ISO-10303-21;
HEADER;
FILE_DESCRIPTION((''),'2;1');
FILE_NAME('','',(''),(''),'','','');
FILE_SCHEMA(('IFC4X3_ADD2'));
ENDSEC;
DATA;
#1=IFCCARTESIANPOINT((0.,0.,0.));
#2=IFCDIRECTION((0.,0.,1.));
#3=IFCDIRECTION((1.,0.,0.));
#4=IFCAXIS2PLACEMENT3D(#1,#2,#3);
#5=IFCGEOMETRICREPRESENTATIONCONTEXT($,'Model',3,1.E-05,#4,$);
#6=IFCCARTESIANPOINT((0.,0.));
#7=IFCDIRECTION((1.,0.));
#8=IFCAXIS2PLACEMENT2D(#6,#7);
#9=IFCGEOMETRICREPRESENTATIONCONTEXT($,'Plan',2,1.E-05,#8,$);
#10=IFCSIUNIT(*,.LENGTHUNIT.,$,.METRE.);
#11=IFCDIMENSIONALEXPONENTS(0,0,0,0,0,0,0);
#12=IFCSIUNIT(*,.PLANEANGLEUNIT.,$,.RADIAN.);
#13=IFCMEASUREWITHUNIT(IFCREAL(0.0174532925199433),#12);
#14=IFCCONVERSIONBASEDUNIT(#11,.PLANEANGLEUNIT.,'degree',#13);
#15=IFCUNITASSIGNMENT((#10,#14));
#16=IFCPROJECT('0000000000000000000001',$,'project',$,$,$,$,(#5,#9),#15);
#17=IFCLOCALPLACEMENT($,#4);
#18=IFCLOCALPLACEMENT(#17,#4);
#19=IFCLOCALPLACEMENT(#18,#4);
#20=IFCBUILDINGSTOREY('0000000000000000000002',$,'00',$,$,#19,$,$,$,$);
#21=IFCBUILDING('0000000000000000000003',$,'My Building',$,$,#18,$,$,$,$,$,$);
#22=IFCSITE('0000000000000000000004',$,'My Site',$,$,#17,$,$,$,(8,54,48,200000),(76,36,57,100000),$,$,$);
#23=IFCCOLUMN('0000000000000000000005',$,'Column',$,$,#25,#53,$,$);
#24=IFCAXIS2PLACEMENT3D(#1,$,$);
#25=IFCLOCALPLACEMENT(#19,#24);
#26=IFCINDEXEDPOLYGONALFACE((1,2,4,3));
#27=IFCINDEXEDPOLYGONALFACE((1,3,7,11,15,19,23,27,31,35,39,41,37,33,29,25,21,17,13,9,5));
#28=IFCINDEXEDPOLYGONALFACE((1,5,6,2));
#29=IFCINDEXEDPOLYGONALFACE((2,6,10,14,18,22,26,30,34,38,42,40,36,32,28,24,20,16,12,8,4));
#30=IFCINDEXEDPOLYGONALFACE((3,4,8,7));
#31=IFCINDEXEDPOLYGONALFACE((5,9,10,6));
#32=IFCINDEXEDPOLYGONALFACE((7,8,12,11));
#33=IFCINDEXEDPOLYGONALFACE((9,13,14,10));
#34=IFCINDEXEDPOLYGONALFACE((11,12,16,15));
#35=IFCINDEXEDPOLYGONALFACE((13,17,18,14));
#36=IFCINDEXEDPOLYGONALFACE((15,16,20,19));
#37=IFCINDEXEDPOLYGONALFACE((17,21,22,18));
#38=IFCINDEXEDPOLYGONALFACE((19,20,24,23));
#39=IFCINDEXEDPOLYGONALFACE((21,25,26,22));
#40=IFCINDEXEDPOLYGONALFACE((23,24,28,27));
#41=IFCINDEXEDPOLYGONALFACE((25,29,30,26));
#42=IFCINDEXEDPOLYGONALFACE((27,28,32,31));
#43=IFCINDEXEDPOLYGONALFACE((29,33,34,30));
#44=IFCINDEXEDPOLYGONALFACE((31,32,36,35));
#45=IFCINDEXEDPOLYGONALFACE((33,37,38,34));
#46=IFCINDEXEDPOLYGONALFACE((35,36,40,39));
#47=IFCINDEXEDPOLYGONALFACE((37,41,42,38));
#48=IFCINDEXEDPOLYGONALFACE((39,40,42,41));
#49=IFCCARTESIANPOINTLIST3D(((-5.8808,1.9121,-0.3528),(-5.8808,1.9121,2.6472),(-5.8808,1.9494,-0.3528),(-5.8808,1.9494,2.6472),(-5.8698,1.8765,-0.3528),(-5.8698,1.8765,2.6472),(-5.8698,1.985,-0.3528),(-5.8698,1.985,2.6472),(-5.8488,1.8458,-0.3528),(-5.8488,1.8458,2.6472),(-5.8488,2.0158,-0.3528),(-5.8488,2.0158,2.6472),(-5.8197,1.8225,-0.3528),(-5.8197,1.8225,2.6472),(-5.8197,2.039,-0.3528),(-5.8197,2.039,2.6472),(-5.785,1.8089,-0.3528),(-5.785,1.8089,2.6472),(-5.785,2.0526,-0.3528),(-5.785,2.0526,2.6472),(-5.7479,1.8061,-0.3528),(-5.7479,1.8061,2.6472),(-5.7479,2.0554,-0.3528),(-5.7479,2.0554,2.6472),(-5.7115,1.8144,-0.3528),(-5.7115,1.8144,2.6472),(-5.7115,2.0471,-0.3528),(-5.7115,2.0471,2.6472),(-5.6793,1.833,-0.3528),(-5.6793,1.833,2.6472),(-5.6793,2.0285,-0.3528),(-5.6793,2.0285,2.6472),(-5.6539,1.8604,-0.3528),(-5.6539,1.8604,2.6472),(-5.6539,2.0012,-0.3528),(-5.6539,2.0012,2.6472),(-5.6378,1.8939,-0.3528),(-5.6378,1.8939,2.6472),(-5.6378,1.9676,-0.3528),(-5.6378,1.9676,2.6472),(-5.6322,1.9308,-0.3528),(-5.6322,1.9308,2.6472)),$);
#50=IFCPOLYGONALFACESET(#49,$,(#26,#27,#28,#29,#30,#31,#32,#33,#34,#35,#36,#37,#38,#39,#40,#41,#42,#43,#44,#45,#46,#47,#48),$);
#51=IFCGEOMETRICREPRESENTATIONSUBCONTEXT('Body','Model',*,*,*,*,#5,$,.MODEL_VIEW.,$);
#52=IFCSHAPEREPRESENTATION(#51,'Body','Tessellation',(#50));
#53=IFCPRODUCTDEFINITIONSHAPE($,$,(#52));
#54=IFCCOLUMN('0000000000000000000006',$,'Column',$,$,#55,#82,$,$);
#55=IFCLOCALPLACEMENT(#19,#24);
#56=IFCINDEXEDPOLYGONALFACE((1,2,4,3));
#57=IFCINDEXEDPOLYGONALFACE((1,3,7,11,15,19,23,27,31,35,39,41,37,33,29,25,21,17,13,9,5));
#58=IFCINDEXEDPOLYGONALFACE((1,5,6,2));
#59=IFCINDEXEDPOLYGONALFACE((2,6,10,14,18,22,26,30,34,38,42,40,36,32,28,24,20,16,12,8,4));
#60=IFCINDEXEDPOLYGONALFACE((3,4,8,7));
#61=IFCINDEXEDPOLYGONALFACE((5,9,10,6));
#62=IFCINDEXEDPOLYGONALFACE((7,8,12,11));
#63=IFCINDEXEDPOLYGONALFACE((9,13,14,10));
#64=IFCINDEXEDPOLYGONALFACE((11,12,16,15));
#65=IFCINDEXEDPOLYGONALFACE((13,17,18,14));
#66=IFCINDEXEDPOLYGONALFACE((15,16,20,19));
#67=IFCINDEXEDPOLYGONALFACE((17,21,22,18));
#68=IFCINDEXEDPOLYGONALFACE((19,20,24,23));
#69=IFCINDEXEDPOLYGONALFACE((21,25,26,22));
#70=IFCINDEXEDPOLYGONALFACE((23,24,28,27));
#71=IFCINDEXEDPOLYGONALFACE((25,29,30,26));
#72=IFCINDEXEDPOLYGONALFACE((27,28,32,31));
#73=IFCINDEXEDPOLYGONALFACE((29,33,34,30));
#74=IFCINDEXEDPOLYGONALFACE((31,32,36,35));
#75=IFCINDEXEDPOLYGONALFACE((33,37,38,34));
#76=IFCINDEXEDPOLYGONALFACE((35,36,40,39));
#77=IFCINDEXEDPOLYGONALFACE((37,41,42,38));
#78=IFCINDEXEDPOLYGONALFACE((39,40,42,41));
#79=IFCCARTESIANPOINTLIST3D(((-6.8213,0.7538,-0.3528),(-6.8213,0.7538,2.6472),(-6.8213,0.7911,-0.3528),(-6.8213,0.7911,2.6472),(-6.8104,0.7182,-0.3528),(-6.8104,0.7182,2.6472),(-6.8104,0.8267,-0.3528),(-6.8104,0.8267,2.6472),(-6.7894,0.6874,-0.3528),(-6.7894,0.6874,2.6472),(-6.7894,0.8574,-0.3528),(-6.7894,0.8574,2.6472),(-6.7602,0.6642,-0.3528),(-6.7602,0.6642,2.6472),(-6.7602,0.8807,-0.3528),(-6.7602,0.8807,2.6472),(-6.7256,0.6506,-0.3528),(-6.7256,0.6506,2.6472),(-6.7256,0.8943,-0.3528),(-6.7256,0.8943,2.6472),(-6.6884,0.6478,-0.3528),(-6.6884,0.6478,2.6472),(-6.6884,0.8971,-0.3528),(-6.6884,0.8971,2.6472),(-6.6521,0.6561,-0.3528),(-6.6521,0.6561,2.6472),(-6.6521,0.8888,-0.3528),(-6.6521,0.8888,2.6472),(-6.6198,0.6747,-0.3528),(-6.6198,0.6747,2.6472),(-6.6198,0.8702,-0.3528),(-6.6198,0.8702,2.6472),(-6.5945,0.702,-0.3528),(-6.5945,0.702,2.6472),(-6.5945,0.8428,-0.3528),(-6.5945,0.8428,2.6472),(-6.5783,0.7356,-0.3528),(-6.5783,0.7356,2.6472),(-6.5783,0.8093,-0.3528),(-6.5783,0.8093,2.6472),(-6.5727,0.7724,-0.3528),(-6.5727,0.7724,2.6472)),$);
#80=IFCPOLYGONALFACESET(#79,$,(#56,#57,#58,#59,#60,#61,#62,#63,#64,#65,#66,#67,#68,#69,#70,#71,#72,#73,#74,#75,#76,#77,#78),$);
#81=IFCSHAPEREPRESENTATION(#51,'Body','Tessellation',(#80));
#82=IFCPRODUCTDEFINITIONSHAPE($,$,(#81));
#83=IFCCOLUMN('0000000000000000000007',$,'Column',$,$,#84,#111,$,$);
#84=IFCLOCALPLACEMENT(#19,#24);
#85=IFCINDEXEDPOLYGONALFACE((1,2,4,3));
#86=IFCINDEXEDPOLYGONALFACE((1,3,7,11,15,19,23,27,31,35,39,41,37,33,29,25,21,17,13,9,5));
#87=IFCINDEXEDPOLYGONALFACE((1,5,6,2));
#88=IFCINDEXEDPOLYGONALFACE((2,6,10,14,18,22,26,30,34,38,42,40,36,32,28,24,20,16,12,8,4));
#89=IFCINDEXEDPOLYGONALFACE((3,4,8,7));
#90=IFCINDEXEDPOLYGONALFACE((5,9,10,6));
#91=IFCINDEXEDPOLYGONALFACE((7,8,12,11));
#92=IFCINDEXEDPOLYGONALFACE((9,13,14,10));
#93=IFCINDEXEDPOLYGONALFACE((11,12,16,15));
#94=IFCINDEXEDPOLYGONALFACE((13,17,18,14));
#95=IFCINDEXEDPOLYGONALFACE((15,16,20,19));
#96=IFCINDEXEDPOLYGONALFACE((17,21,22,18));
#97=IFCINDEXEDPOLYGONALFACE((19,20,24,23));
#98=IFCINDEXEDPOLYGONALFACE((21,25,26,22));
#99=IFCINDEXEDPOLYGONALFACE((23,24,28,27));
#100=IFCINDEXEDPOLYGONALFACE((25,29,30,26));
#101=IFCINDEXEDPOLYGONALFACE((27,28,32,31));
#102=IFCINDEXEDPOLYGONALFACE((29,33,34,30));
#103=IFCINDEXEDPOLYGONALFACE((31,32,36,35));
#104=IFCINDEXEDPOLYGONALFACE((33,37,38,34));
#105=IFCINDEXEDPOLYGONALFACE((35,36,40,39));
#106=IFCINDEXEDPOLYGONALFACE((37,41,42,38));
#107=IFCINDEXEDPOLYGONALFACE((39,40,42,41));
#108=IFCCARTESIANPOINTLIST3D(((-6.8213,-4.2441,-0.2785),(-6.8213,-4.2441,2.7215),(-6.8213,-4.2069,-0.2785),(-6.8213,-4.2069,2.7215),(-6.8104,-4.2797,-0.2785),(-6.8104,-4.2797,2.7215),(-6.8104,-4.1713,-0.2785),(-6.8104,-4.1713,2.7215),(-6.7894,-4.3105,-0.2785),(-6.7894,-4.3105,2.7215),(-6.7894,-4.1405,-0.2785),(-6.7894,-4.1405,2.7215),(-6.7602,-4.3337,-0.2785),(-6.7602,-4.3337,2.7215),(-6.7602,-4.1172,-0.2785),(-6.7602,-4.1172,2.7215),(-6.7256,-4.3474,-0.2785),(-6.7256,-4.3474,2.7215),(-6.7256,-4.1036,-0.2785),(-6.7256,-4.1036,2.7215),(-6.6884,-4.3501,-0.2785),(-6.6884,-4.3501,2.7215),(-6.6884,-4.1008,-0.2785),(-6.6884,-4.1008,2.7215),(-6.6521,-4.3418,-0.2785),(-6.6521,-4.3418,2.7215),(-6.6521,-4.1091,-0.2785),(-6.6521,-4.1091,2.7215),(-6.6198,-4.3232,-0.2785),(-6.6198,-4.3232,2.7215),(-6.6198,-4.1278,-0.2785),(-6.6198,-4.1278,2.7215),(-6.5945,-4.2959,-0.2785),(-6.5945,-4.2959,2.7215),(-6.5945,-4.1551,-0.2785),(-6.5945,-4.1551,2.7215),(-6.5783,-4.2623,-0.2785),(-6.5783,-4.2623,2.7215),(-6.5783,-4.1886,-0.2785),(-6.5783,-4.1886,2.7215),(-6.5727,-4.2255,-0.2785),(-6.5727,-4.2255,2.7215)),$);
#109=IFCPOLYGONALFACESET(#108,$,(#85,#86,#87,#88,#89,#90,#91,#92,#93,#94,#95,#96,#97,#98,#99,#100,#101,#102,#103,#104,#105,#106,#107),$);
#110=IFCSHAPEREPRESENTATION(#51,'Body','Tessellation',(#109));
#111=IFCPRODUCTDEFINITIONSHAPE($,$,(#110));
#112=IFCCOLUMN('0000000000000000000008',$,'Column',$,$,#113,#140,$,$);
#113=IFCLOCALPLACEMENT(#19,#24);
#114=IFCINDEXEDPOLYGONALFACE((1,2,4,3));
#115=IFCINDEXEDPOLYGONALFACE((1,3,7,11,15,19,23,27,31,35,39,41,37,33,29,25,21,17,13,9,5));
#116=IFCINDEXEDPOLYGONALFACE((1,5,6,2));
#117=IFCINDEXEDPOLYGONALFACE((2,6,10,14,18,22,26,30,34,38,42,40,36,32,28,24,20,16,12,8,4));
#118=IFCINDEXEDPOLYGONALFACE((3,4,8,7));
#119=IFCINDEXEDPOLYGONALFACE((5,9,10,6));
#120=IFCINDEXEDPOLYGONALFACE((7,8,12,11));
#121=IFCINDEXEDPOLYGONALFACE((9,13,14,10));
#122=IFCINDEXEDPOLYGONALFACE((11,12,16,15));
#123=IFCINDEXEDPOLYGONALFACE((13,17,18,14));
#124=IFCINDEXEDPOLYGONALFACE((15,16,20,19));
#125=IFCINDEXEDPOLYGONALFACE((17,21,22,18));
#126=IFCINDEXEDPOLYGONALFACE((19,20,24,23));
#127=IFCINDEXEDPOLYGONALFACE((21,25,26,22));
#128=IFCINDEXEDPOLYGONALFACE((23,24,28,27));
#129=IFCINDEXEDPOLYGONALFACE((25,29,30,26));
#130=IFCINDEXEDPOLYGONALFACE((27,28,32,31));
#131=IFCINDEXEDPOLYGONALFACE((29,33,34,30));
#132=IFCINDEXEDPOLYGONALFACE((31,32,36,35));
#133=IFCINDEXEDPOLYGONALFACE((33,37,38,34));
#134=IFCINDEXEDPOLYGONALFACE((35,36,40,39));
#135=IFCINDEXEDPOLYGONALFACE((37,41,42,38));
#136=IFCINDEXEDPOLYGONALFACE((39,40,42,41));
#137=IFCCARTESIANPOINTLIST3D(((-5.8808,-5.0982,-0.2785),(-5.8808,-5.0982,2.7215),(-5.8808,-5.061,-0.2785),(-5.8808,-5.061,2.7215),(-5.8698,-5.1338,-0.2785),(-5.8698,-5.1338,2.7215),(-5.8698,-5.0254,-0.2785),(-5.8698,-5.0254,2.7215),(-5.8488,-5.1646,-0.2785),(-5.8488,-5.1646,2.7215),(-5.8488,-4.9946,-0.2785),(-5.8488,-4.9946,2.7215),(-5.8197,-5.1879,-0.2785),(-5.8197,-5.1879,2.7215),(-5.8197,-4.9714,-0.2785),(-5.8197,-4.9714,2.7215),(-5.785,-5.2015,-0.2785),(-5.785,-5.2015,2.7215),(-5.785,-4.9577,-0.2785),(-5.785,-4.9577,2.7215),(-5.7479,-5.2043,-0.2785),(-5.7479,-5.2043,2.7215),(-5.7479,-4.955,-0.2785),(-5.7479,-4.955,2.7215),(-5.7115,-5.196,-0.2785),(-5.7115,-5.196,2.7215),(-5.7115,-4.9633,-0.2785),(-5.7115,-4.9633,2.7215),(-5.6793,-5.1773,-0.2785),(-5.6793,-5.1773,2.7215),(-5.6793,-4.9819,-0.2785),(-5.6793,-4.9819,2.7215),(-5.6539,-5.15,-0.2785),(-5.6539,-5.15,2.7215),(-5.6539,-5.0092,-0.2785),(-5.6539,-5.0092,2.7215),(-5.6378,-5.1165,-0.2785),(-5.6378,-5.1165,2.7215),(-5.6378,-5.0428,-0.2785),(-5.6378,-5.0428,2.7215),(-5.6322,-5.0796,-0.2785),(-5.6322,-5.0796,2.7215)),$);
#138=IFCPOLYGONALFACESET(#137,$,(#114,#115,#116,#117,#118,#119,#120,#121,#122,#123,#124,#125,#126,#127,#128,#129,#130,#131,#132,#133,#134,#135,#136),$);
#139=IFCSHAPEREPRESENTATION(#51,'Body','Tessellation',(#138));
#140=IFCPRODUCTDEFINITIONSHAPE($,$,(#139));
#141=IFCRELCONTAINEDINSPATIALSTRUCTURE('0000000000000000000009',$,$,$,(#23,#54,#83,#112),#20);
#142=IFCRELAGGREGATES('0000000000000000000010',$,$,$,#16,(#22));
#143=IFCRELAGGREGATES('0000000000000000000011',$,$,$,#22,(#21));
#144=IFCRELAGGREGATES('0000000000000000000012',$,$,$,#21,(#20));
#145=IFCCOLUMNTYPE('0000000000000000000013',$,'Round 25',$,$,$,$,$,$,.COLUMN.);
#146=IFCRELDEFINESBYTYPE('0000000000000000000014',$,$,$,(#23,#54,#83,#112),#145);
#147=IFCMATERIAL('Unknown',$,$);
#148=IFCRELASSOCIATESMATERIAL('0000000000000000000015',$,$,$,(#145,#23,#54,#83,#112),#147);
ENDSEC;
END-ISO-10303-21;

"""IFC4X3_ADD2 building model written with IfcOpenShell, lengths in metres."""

from ifc_helpers import new_model, entity, si_unit, converted_unit, frame, origin_with_axes, origin_2d_with_axis, place, context, subcontext, project, spatial, circle, extrude, material, material_profile, profile_set, profile_usage, type_object, element, save


model = new_model("IFC4X3_ADD2")

# Units and contexts
model_context = context("Model", 3, precision=1e-05, world=origin_with_axes())
plan_context = context("Plan", 2, precision=1e-05, world=origin_2d_with_axis())
body_context = subcontext(model_context, "Body", "Model", "MODEL_VIEW")
ifc_project = project(units=[si_unit("LENGTHUNIT", "METRE"), converted_unit("PLANEANGLEUNIT", "degree", entity("IfcReal", 0.0174532925199433), si_unit("PLANEANGLEUNIT", "RADIAN"), dimensions=[0, 0, 0, 0, 0, 0, 0])], contexts=[model_context, plan_context])

# Site, building, storey
site_placement = place(None, origin_with_axes())
site = spatial("IfcSite", under=ifc_project, at=site_placement, Name="My Site", RefLatitude=(8, 54, 48, 200000), RefLongitude=(76, 36, 57, 100000))
building_placement = place(site_placement, origin_with_axes())
building = spatial("IfcBuilding", under=site, at=building_placement, Name="My Building")
storey_placement = place(building_placement, origin_with_axes())
storey = spatial("IfcBuildingStorey", under=building, at=storey_placement, Name="00")

# Columns
ifc_material = material(Name="Unknown")
ifc_material_profile = material_profile(ifc_material, circle(Radius=0.125))
ifc_profile_set = profile_set([ifc_material_profile])
ifc_profile_usage_1 = profile_usage(ifc_profile_set, cardinal=5)
column_type = type_object("IfcColumnType", Name="Round 25", PredefinedType="COLUMN", material=ifc_profile_set)
column_1_placement = place(storey_placement, frame((-5.7572, 1.9308, -0.3528), z_axis=(0.0, 0.0, 1.0), x_axis=(1.0, 0.0, 0.0)))
element("IfcColumn", 1, at=column_1_placement, inside=storey, type_object=column_type, material=ifc_profile_usage_1, Name="Column", context=body_context, shape_type="SweptSolid", body=[
    extrude(circle(Radius=0.125), origin_with_axes(), (0.0, 0.0, 1.0), 3.0),
])
ifc_profile_usage_2 = profile_usage(ifc_profile_set, cardinal=5)
column_2_placement = place(storey_placement, frame((-6.6977, 0.7724, -0.3528), z_axis=(0.0, 0.0, 1.0), x_axis=(1.0, 0.0, 0.0)))
element("IfcColumn", 2, at=column_2_placement, inside=storey, type_object=column_type, material=ifc_profile_usage_2, Name="Column", context=body_context, shape_type="SweptSolid", body=[
    extrude(circle(Radius=0.125), origin_with_axes(), (0.0, 0.0, 1.0), 3.0),
])
ifc_profile_usage_3 = profile_usage(ifc_profile_set, cardinal=5)
column_3_placement = place(storey_placement, frame((-6.6977, -4.2255, -0.2785), z_axis=(0.0, 0.0, 1.0), x_axis=(1.0, 0.0, 0.0)))
element("IfcColumn", 3, at=column_3_placement, inside=storey, type_object=column_type, material=ifc_profile_usage_3, Name="Column", context=body_context, shape_type="SweptSolid", body=[
    extrude(circle(Radius=0.125), origin_with_axes(), (0.0, 0.0, 1.0), 3.0),
])
ifc_profile_usage_4 = profile_usage(ifc_profile_set, cardinal=5)
column_4_placement = place(storey_placement, frame((-5.7572, -5.0796, -0.2785), z_axis=(0.0, 0.0, 1.0), x_axis=(1.0, 0.0, 0.0)))
element("IfcColumn", 4, at=column_4_placement, inside=storey, type_object=column_type, material=ifc_profile_usage_4, Name="Column", context=body_context, shape_type="SweptSolid", body=[
    extrude(circle(Radius=0.125), origin_with_axes(), (0.0, 0.0, 1.0), 3.0),
])

save(model, "model.ifc")
